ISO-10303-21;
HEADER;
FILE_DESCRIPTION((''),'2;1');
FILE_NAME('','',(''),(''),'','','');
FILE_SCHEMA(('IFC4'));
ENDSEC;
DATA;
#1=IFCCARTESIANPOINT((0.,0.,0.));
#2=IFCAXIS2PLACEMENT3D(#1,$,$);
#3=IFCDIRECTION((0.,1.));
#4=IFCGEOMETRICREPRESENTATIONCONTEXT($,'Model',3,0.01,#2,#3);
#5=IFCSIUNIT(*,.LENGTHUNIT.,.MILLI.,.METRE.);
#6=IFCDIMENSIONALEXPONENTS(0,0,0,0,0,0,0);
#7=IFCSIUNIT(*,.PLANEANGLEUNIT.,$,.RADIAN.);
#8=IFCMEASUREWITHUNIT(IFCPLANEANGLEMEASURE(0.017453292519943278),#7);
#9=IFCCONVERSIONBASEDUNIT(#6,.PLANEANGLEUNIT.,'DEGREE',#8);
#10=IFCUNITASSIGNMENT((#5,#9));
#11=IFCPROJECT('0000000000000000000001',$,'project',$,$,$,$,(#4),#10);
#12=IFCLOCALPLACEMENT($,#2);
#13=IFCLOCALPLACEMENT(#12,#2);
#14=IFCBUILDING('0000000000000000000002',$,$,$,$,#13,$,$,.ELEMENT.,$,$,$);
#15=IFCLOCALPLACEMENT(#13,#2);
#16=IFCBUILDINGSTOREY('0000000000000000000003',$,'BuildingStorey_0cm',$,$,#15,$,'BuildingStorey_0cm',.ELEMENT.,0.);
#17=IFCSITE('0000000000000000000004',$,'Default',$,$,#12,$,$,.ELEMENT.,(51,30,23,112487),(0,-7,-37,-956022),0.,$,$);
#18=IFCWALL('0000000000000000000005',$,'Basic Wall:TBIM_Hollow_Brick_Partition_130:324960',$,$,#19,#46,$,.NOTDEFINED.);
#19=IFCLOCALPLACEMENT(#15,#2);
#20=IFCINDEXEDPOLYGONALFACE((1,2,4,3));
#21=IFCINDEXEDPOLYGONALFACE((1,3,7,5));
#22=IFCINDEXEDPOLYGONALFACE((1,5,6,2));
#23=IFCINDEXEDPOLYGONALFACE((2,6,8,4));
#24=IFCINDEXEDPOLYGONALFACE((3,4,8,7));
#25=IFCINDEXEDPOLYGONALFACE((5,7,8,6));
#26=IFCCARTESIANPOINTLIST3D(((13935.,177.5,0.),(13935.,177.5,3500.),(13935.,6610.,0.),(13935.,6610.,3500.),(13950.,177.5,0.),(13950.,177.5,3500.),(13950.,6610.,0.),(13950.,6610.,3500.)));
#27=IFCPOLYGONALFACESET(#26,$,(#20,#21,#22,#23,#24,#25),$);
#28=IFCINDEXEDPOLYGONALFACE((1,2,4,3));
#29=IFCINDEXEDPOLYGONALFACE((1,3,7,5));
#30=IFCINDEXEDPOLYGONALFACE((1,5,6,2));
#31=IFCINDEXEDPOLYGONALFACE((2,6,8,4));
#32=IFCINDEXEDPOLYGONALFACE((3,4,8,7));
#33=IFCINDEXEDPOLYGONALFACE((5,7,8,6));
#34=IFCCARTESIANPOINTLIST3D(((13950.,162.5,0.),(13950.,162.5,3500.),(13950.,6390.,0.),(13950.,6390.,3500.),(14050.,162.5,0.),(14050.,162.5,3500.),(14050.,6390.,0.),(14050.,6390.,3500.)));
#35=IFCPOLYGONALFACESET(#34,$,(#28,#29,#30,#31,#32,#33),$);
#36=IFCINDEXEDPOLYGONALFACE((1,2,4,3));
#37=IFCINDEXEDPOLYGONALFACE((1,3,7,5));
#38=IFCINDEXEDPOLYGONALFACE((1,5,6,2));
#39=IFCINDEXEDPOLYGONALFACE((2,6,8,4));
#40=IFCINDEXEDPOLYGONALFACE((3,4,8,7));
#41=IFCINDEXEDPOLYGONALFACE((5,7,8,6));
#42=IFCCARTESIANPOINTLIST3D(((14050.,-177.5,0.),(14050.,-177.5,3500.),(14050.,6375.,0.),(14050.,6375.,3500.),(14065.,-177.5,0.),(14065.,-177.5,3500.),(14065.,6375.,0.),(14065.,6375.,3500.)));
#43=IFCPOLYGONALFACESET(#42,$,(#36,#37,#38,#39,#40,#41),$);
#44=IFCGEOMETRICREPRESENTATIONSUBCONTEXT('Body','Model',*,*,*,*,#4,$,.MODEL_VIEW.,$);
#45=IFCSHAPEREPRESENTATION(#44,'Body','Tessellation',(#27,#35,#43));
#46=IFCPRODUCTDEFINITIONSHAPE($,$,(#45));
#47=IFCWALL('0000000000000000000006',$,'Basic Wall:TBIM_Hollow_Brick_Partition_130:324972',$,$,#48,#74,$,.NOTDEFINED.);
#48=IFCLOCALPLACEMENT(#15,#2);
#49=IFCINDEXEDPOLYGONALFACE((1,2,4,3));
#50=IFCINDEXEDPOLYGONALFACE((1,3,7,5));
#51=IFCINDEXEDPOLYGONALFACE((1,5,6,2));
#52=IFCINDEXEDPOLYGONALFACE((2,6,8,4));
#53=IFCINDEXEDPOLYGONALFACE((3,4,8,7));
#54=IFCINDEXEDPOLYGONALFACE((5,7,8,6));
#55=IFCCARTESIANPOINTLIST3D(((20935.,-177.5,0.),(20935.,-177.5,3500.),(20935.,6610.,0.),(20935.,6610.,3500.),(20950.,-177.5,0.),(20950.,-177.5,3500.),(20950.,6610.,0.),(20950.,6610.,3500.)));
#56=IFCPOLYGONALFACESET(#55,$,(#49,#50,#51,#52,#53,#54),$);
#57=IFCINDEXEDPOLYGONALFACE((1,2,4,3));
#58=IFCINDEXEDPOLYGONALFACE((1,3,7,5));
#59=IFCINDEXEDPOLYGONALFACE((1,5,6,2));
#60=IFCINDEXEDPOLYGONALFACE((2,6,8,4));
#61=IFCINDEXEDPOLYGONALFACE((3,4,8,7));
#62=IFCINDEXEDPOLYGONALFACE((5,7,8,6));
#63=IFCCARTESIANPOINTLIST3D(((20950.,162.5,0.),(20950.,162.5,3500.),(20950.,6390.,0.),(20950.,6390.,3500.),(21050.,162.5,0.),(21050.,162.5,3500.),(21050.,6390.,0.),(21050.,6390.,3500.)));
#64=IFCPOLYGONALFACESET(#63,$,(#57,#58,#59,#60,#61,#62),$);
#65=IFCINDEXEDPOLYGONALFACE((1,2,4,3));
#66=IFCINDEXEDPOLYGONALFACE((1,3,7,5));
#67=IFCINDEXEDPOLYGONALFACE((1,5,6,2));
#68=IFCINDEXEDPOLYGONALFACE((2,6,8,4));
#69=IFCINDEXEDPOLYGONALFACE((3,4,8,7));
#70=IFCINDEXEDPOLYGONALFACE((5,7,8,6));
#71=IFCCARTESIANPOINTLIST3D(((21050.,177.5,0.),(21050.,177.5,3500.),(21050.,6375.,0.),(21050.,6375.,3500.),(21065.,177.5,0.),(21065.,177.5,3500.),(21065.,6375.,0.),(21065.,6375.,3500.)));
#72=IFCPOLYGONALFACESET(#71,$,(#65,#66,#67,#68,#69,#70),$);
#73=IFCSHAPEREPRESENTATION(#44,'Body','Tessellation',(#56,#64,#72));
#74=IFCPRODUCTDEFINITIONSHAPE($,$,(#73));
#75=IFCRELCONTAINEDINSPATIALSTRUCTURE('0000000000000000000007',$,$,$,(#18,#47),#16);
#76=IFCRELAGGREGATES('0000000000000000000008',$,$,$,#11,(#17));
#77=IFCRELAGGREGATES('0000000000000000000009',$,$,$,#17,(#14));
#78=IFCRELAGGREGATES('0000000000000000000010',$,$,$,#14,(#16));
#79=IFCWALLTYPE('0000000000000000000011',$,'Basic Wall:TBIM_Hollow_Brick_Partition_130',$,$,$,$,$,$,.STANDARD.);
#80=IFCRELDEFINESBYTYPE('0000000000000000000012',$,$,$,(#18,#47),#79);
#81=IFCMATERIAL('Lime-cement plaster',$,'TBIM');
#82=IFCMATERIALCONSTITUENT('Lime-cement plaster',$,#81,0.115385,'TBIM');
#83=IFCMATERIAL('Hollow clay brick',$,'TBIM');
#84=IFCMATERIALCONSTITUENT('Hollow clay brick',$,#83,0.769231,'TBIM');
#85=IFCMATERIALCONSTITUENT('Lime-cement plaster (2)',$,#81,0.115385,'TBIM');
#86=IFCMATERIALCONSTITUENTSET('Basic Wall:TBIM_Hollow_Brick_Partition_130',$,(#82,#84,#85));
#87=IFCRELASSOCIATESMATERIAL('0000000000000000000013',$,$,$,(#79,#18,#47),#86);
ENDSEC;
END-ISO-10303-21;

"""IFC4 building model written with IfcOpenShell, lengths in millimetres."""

from ifc_helpers import new_model, entity, si_unit, converted_unit, direction, frame, origin, place, context, subcontext, project, spatial, indexed_curve, outline, extrude, material, constituent, constituent_set, type_object, element, save


model = new_model("IFC4")

# Units and contexts
model_context = context("Model", 3, precision=0.01, world=origin(), true_north=direction((0.0, 1.0)))
body_context = subcontext(model_context, "Body", "Model", "MODEL_VIEW")
ifc_project = project(units=[si_unit("LENGTHUNIT", "METRE", prefix="MILLI"), converted_unit("PLANEANGLEUNIT", "DEGREE", entity("IfcPlaneAngleMeasure", 0.017453292519943278), si_unit("PLANEANGLEUNIT", "RADIAN"), dimensions=[0, 0, 0, 0, 0, 0, 0])], contexts=[model_context])

# Site, building, storey
site_placement = place(None, origin())
site = spatial("IfcSite", under=ifc_project, at=site_placement, Name="Default", CompositionType="ELEMENT", RefLatitude=(51, 30, 23, 112487), RefLongitude=(0, -7, -37, -956022), RefElevation=0.0)
building_placement = place(site_placement, origin())
building = spatial("IfcBuilding", under=site, at=building_placement, CompositionType="ELEMENT")
storey_placement = place(building_placement, origin())
storey = spatial("IfcBuildingStorey", under=building, at=storey_placement, Name="BuildingStorey_0cm", LongName="BuildingStorey_0cm", CompositionType="ELEMENT", Elevation=0.0)

# Shared definitions
ifc_material_1 = material(Name="Lime-cement plaster", Category="TBIM")

# Walls
ifc_constituent_1 = constituent(ifc_material_1, Name="Lime-cement plaster", Category="TBIM", fraction=0.115385)
ifc_material_2 = material(Name="Hollow clay brick", Category="TBIM")
ifc_constituent_2 = constituent(ifc_material_2, Name="Hollow clay brick", Category="TBIM", fraction=0.769231)
ifc_constituent_3 = constituent(ifc_material_1, Name="Lime-cement plaster (2)", Category="TBIM", fraction=0.115385)
ifc_constituent_set_1 = constituent_set(constituents=[ifc_constituent_1, ifc_constituent_2, ifc_constituent_3], Name="Basic Wall:TBIM_Hollow_Brick_Partition_130")
wall_type_1 = type_object("IfcWallType", Name="Basic Wall:TBIM_Hollow_Brick_Partition_130", PredefinedType="STANDARD", material=ifc_constituent_set_1)
wall_1_placement = place(storey_placement, frame((14000.0, 177.5, 0.0), z_axis=(0.0, 0.0, 1.0), x_axis=(0.0, 1.0, 0.0)))
element("IfcWall", 1, at=wall_1_placement, inside=storey, type_object=wall_type_1, material=ifc_constituent_set_1, Name="Basic Wall:TBIM_Hollow_Brick_Partition_130:324960", PredefinedType="NOTDEFINED", context=body_context, shape_type="SweptSolid", body=[
    extrude(outline(indexed_curve([(-7.5, -3216.2), (7.5, -3216.2), (7.5, 3216.2), (-7.5, 3216.2), (-7.5, -3216.2)], self_intersect=False)), frame((3216.2, 57.5, 0.0), z_axis=(0.0, 0.0, 1.0), x_axis=(0.0, -1.0, 0.0)), (0.0, 0.0, 1.0), 3500.0),
    extrude(outline(indexed_curve([(-3113.8, -50.0), (3113.8, -50.0), (3113.8, 50.0), (-3113.8, 50.0), (-3113.8, -50.0)], self_intersect=False)), frame((3098.8, 0.0, 0.0)), (0.0, 0.0, 1.0), 3500.0),
    extrude(outline(indexed_curve([(-7.5, -3276.2), (7.5, -3276.2), (7.5, 3276.2), (-7.5, 3276.2), (-7.5, -3276.2)], self_intersect=False)), frame((2921.3, -57.5, 0.0), z_axis=(0.0, 0.0, 1.0), x_axis=(0.0, 1.0, 0.0)), (0.0, 0.0, 1.0), 3500.0),
])
wall_2_placement = place(storey_placement, frame((21000.0, 177.5, 0.0), z_axis=(0.0, 0.0, 1.0), x_axis=(0.0, 1.0, 0.0)))
element("IfcWall", 2, at=wall_2_placement, inside=storey, type_object=wall_type_1, material=ifc_constituent_set_1, Name="Basic Wall:TBIM_Hollow_Brick_Partition_130:324972", PredefinedType="NOTDEFINED", context=body_context, shape_type="SweptSolid", body=[
    extrude(outline(indexed_curve([(-7.5, -3393.7), (7.5, -3393.7), (7.5, 3393.7), (-7.5, 3393.7), (-7.5, -3393.7)], self_intersect=False)), frame((3038.8, 57.5, 0.0), z_axis=(0.0, 0.0, 1.0), x_axis=(0.0, -1.0, 0.0)), (0.0, 0.0, 1.0), 3500.0),
    extrude(outline(indexed_curve([(-3113.8, -50.0), (3113.8, -50.0), (3113.8, 50.0), (-3113.8, 50.0), (-3113.8, -50.0)], self_intersect=False)), frame((3098.8, 0.0, 0.0)), (0.0, 0.0, 1.0), 3500.0),
    extrude(outline(indexed_curve([(-7.5, -3098.7), (7.5, -3098.7), (7.5, 3098.8), (-7.5, 3098.8), (-7.5, -3098.7)], self_intersect=False)), frame((3098.8, -57.5, 0.0), z_axis=(0.0, 0.0, 1.0), x_axis=(0.0, 1.0, 0.0)), (0.0, 0.0, 1.0), 3500.0),
])

save(model, "model.ifc")
